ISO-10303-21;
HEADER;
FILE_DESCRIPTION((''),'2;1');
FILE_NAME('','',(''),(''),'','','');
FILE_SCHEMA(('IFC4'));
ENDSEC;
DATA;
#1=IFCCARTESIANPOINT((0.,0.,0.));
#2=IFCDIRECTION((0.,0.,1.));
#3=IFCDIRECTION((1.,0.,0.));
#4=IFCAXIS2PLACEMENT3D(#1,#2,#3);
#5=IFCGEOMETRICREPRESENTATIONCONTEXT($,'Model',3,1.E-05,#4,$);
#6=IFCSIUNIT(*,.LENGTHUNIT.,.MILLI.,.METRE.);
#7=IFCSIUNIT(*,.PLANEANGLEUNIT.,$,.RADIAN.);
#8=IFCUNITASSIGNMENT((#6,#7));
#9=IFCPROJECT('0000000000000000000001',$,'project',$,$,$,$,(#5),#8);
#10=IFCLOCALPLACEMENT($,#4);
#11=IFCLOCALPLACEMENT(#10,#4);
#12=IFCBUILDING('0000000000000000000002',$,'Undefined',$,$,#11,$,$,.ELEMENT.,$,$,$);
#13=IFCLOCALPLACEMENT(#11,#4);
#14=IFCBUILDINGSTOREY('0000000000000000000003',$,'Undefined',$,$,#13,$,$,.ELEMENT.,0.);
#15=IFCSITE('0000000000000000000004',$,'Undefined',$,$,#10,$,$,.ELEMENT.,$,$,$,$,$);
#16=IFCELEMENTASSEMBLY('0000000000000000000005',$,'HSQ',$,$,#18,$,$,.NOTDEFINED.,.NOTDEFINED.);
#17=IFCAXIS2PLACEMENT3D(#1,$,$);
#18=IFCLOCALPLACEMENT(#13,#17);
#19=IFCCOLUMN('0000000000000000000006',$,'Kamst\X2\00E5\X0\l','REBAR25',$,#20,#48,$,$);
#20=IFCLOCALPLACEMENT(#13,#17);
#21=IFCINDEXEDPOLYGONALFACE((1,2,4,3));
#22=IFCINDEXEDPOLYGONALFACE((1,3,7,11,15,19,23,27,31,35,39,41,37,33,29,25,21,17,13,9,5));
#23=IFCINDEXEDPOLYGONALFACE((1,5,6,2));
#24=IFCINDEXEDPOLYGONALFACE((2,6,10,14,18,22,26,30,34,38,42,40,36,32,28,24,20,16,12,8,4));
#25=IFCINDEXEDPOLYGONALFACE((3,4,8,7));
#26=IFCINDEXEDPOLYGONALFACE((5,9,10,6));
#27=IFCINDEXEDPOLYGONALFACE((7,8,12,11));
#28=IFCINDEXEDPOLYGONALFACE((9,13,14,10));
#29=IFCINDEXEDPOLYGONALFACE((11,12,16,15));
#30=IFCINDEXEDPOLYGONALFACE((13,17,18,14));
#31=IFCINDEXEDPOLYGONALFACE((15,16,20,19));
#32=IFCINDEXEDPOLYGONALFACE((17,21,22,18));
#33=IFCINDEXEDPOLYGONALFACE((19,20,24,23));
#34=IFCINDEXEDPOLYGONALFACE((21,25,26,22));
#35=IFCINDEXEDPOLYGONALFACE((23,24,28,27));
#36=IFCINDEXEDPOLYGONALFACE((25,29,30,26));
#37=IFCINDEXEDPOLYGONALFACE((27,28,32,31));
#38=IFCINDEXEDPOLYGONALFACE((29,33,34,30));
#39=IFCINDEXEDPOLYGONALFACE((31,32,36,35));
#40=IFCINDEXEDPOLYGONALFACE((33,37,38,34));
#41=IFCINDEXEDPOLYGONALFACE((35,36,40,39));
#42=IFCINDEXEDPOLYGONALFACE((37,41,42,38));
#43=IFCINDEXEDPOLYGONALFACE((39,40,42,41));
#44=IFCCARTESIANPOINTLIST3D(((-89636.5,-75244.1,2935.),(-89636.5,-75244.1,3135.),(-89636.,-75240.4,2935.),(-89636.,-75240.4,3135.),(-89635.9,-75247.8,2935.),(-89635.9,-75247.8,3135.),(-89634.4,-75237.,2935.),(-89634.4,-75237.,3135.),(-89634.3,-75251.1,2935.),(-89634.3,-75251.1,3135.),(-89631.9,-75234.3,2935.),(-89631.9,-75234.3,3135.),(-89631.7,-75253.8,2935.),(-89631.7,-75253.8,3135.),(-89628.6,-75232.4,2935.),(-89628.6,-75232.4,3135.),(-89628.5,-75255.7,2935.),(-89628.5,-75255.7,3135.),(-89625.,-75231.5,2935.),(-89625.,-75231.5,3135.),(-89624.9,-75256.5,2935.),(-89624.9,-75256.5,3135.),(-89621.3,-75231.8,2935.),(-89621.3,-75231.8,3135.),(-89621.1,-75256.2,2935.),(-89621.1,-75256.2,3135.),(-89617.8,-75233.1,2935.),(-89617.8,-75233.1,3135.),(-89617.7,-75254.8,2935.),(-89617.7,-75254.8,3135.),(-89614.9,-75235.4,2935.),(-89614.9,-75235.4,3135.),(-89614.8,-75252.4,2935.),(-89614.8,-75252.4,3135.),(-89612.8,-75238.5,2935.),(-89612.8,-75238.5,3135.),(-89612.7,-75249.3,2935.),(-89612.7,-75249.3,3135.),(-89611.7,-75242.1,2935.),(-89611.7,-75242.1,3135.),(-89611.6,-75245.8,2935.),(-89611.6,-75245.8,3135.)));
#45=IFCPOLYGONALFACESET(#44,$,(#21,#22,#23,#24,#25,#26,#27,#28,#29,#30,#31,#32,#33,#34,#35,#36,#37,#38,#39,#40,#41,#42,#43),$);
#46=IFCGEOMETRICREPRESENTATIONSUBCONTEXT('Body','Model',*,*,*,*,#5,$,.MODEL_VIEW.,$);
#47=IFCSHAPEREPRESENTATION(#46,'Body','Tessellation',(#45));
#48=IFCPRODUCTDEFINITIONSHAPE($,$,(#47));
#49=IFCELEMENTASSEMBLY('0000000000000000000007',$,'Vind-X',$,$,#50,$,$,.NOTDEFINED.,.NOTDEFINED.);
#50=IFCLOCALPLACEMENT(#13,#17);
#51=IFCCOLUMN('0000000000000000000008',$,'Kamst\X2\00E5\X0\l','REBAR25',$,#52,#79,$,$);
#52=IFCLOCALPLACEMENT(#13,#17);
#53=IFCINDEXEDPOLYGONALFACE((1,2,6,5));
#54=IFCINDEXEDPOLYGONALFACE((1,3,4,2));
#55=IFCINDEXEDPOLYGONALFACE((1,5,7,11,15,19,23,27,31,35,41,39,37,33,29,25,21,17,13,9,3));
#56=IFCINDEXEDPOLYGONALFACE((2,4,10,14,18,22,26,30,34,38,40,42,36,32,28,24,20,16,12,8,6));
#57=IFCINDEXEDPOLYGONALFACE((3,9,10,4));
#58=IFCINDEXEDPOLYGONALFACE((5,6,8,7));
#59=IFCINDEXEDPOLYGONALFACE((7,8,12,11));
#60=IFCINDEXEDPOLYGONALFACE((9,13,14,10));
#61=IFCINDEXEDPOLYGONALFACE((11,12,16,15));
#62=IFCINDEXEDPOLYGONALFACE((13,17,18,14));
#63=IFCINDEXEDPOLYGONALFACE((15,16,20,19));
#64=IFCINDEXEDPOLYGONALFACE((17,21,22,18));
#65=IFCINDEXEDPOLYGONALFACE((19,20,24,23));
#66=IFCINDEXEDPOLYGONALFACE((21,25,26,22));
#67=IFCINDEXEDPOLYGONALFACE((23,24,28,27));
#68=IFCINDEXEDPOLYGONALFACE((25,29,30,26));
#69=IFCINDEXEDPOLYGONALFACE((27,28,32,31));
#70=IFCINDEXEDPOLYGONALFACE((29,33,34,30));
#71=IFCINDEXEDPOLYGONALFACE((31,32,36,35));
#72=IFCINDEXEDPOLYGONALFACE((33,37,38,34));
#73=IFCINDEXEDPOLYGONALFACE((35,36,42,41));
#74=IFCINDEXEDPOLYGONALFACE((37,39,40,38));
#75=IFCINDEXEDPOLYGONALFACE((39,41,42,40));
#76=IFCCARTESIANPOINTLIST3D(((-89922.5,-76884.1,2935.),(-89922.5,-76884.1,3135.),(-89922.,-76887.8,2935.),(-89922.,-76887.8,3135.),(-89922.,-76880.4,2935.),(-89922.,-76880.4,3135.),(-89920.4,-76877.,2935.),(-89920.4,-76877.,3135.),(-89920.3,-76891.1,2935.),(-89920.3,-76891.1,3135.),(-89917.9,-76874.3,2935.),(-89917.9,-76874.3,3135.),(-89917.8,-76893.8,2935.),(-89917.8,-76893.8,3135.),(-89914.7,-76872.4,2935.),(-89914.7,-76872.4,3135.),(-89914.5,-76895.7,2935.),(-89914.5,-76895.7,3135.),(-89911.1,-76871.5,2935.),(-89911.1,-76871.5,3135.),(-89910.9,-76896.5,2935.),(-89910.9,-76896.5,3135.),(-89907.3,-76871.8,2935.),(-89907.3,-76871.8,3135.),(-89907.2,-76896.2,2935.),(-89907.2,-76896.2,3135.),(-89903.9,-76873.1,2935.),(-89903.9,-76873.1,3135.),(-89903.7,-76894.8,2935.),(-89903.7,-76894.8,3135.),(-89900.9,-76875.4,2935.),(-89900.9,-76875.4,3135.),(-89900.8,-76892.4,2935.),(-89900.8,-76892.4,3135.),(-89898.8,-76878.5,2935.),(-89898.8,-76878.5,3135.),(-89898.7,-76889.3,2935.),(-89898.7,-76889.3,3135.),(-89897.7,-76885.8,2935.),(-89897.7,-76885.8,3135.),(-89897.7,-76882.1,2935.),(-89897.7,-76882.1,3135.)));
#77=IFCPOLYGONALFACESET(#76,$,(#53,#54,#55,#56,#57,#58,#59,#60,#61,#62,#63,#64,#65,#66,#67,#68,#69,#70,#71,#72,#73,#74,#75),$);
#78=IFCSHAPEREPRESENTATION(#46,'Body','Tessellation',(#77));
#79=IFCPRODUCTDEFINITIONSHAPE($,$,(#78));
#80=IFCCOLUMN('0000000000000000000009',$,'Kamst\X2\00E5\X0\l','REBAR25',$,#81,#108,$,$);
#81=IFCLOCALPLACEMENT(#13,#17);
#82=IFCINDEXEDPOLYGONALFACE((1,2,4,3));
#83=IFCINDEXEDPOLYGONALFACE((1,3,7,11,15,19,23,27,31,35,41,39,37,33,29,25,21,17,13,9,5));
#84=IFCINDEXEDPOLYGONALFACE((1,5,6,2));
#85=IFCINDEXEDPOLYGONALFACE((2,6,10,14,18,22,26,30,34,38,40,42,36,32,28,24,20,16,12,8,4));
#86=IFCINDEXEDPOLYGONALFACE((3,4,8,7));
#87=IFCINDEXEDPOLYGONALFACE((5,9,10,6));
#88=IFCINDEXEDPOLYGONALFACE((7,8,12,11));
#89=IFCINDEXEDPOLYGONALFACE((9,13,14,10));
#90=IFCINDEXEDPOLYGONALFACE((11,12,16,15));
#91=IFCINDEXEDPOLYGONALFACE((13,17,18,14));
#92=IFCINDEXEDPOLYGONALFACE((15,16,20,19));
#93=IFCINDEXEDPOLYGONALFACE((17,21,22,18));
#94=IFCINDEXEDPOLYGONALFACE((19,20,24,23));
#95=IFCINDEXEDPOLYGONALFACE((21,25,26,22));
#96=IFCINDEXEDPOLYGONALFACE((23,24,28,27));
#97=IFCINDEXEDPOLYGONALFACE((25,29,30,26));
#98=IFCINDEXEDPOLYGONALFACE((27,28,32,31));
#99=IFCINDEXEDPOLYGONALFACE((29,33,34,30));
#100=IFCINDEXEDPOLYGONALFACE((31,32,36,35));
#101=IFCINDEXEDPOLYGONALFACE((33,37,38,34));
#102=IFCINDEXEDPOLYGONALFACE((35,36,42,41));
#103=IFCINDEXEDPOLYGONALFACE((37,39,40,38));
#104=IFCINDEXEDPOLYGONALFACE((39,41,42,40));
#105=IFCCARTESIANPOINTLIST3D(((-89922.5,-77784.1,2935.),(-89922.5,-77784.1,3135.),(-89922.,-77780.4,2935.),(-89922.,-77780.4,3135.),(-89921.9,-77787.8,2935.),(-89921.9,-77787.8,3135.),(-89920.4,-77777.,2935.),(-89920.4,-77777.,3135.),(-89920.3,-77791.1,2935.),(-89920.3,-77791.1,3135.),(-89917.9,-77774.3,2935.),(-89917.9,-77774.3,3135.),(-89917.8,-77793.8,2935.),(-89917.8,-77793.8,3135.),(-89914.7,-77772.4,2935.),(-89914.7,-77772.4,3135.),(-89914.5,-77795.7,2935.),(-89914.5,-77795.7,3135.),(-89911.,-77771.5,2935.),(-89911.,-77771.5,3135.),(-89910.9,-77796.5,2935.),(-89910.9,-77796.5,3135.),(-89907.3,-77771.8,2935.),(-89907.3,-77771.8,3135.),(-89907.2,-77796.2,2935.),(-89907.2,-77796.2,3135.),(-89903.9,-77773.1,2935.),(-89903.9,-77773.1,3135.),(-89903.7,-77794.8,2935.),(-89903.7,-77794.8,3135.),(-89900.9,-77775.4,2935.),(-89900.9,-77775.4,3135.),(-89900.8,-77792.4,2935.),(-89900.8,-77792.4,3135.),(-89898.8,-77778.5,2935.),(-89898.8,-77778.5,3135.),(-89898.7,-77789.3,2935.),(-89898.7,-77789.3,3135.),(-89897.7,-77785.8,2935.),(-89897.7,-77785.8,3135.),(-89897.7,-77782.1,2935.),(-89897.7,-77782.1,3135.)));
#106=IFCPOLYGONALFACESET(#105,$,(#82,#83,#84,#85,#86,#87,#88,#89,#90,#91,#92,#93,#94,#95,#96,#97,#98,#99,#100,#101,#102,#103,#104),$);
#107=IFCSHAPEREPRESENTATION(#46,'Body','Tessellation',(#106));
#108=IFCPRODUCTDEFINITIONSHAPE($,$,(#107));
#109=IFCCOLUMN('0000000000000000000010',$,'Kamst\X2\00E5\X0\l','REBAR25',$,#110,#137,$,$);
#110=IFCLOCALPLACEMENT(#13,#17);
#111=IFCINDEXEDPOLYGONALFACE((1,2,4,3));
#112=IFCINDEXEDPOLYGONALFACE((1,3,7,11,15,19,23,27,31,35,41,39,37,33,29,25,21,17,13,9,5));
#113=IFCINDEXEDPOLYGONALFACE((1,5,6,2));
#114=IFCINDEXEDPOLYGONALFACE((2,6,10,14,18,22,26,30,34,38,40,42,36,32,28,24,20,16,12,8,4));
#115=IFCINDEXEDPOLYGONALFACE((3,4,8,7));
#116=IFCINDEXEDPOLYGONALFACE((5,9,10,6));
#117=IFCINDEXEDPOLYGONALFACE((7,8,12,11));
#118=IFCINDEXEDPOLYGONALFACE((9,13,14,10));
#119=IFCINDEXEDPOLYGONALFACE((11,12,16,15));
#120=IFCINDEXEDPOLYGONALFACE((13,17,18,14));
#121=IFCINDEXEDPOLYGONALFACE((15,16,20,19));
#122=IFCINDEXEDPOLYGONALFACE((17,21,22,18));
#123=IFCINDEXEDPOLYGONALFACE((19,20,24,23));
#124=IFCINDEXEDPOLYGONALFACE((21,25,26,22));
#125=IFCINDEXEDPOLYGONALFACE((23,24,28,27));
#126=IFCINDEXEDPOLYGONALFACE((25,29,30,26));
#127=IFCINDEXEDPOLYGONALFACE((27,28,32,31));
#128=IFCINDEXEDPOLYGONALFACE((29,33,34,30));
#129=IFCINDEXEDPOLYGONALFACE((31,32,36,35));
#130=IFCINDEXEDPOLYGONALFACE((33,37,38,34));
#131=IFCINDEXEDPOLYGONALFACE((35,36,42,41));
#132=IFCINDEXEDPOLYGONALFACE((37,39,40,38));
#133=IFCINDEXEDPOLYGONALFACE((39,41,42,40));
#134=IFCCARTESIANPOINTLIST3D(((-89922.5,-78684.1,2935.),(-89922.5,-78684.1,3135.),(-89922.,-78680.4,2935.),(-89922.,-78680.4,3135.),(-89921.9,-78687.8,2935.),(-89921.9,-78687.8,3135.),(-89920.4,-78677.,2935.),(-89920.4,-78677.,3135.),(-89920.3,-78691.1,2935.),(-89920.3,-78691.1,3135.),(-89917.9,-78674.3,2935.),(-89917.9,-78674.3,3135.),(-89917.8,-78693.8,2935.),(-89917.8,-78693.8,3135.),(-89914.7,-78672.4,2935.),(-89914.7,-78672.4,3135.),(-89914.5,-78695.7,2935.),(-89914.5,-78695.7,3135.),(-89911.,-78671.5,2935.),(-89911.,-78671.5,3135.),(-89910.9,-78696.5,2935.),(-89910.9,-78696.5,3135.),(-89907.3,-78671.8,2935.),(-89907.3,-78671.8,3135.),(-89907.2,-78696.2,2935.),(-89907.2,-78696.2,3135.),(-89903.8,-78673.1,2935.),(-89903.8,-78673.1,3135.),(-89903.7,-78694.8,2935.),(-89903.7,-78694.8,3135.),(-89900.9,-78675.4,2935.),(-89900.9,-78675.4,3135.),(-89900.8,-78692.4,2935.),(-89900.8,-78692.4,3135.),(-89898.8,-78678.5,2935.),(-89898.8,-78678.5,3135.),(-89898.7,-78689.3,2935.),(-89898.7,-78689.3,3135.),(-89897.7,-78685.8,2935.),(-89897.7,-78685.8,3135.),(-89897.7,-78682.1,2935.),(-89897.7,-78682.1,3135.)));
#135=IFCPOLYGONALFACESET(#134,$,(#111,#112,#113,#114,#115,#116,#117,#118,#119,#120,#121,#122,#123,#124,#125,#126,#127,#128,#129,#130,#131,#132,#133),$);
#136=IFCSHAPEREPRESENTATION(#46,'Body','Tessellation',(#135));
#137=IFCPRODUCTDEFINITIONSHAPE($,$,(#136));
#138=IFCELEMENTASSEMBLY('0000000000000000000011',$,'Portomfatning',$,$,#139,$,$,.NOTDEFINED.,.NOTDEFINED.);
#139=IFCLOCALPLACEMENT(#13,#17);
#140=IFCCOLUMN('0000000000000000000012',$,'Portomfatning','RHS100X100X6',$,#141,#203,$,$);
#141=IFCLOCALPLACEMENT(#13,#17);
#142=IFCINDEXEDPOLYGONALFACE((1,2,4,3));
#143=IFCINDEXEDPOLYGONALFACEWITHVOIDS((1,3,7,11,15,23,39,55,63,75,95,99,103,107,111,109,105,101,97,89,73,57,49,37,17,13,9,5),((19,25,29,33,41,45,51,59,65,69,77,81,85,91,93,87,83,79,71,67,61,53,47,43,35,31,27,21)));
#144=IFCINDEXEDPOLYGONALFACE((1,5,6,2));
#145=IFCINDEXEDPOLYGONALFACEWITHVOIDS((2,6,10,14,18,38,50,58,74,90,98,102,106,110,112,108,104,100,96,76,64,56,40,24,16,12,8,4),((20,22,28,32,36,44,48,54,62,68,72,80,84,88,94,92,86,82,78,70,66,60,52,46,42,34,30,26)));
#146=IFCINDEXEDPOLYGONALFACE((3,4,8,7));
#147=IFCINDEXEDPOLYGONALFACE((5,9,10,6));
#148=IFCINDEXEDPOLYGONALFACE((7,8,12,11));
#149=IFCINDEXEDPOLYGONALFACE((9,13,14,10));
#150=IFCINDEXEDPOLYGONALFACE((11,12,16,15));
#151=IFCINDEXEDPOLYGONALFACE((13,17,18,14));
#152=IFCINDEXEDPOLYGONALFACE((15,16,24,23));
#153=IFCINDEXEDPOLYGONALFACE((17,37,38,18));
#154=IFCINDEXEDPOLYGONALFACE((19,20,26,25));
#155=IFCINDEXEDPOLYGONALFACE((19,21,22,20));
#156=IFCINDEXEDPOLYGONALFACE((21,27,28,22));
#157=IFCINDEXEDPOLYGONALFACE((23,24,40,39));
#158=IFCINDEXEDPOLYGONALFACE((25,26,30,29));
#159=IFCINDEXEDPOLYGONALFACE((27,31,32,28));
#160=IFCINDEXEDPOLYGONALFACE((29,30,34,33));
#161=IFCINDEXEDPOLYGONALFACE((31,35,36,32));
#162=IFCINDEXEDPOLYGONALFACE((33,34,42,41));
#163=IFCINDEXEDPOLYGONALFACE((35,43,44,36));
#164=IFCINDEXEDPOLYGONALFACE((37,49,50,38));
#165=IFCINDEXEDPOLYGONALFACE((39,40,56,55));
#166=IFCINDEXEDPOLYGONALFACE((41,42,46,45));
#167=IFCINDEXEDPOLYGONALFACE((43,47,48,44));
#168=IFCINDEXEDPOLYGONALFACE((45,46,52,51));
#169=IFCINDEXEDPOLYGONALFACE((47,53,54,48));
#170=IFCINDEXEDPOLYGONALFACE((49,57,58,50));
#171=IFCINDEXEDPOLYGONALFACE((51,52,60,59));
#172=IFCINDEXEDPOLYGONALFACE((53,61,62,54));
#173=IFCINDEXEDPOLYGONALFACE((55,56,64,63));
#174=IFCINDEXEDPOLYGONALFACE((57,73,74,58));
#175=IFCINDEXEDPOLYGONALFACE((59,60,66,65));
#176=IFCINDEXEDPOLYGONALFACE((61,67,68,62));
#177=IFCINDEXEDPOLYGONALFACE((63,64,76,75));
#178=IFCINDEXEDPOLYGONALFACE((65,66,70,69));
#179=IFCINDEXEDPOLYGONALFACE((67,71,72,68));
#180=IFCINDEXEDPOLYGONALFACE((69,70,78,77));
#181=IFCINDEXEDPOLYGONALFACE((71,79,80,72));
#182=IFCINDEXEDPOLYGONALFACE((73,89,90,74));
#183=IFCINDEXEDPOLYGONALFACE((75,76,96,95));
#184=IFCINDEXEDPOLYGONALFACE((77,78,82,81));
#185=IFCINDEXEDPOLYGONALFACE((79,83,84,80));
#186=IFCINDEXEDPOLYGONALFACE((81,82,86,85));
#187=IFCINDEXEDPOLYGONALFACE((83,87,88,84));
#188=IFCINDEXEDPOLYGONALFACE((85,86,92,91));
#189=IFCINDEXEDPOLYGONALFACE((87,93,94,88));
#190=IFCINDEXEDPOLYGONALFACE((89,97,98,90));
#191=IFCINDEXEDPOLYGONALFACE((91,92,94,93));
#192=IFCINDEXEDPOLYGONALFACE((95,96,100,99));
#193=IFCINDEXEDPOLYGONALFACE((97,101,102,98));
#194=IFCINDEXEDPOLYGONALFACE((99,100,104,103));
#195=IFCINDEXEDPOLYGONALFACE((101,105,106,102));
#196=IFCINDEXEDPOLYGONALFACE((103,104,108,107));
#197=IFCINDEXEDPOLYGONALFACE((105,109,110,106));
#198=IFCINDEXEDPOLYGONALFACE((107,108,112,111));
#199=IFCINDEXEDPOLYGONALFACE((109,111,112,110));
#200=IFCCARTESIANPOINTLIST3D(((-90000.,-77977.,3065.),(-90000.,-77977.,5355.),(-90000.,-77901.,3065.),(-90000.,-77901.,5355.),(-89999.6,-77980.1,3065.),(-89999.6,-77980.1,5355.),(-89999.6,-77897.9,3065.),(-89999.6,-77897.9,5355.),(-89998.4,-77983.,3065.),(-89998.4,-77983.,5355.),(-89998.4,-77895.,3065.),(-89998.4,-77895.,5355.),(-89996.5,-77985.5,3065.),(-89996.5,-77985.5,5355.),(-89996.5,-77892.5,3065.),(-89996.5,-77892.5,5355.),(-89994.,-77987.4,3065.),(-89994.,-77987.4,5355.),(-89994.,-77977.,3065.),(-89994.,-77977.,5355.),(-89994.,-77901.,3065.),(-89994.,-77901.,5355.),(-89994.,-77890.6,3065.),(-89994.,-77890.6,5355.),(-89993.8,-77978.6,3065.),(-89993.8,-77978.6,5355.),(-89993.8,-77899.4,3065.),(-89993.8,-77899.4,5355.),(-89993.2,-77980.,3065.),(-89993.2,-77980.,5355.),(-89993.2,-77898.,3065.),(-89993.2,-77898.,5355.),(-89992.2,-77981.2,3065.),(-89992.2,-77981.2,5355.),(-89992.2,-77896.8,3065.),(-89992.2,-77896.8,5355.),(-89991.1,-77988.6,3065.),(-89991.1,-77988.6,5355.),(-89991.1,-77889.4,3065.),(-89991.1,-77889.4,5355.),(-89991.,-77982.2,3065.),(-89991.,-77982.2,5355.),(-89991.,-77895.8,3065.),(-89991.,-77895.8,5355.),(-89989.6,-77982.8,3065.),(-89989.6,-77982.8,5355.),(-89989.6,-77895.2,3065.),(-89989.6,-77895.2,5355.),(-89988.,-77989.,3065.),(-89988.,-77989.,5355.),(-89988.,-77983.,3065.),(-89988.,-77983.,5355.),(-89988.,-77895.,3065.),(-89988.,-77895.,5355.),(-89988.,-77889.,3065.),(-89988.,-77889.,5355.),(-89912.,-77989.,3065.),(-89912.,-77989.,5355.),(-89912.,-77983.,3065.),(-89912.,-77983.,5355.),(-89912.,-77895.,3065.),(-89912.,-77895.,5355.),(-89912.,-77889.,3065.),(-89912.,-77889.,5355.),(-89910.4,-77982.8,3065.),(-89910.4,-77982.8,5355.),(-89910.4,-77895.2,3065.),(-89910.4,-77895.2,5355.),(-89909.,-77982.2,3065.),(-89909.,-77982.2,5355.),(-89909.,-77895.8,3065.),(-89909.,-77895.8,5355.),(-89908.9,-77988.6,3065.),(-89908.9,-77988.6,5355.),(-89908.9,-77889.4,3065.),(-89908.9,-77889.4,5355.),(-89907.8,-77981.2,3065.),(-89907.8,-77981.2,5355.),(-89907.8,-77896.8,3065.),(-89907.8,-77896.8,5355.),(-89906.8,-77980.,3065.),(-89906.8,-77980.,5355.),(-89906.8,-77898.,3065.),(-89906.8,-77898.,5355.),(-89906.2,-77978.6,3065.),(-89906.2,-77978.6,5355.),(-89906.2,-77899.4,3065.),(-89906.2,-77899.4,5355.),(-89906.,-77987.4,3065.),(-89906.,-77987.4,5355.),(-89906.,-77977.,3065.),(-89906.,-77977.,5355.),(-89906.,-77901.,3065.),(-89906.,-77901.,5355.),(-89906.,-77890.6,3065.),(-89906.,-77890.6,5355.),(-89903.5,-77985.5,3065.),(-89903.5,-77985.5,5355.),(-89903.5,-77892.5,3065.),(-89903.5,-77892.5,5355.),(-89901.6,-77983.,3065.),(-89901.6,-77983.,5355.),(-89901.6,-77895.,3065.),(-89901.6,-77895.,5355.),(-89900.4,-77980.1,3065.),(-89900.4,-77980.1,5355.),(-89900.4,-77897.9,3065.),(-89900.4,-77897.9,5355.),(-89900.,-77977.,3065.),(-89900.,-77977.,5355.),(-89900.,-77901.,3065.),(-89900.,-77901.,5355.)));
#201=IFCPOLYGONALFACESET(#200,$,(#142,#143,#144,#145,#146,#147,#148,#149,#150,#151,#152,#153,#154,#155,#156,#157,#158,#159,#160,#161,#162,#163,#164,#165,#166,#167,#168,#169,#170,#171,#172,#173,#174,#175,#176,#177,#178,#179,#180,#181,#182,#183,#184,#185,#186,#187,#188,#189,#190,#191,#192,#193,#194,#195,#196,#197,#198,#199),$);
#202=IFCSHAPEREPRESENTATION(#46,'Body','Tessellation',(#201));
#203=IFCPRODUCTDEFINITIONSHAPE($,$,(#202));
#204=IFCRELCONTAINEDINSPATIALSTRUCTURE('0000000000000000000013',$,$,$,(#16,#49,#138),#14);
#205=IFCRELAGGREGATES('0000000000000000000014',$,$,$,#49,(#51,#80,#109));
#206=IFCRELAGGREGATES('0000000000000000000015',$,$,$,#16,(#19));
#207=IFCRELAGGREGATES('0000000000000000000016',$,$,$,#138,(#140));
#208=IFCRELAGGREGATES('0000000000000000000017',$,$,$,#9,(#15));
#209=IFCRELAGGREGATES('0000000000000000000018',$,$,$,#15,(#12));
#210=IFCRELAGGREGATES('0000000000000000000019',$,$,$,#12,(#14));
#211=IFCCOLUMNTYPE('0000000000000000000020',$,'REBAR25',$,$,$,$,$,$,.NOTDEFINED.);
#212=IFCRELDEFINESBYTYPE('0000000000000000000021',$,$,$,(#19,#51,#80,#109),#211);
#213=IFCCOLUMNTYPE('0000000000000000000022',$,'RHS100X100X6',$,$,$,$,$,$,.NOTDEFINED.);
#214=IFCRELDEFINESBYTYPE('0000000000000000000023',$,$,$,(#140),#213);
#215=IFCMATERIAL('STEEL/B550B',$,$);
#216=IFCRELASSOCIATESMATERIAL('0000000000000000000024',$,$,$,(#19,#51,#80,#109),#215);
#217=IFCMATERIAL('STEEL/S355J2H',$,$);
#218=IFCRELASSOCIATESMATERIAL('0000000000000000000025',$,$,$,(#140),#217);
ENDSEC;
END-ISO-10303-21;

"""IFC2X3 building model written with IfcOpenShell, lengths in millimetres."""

from ifc_helpers import new_model, si_unit, frame, origin_with_axes, origin_2d_with_axis, place, context, subcontext, project, spatial, hollow_rectangle, circle, extrude, clip, halfspace, material, type_object, element, aggregate, save


model = new_model("IFC2X3")

# Units and contexts
model_context = context("Model", 3, precision=1e-05, world=origin_with_axes())
body_context = subcontext(model_context, "Body", "Model", "MODEL_VIEW")
ifc_project = project(units=[si_unit("LENGTHUNIT", "METRE", prefix="MILLI"), si_unit("PLANEANGLEUNIT", "RADIAN")], contexts=[model_context])

# Site, building, storey
site_placement = place(None, origin_with_axes())
site = spatial("IfcSite", under=ifc_project, at=site_placement, Name="Undefined", CompositionType="ELEMENT")
building_placement = place(site_placement, origin_with_axes())
building = spatial("IfcBuilding", under=site, at=building_placement, Name="Undefined", CompositionType="ELEMENT")
storey_placement = place(building_placement, origin_with_axes())
storey = spatial("IfcBuildingStorey", under=building, at=storey_placement, Name="Undefined", CompositionType="ELEMENT", Elevation=0.0)

# Element assembly, column
assembly_1_placement = place(storey_placement, origin_with_axes())
assembly_1 = element("IfcElementAssembly", 1, at=assembly_1_placement, inside=storey, Name="HSQ", AssemblyPlace="NOTDEFINED", PredefinedType="NOTDEFINED")
ifc_material_1 = material(Name="STEEL/B550B")
column_type_1 = type_object("IfcColumnType", Name="REBAR25", PredefinedType="NOTDEFINED")
column_1_placement = place(assembly_1_placement, frame((-89624.0, -75244.0, 2935.0), z_axis=(0.0, 0.0, 1.0), x_axis=(-0.862746, -0.505638, 0.0)))
column_1 = element("IfcColumn", 2, at=column_1_placement, type_object=column_type_1, material=ifc_material_1, Name="Kamstål", Description="REBAR25", context=body_context, shape_type="SweptSolid", body=[
    extrude(circle(Radius=12.5, at=origin_2d_with_axis()), frame((0.0, 0.0, 200.0), z_axis=(0.0, 0.0, -1.0), x_axis=(0.0, 1.0, 0.0)), (0.0, 0.0, 1.0), 200.0),
])

# Element assembly, columns
assembly_2_placement = place(storey_placement, origin_with_axes())
assembly_2 = element("IfcElementAssembly", 3, at=assembly_2_placement, inside=storey, Name="Vind-X", AssemblyPlace="NOTDEFINED", PredefinedType="NOTDEFINED")
column_2_placement = place(assembly_2_placement, frame((-89910.0, -76884.0, 2935.0), z_axis=(0.0, 0.0, 1.0), x_axis=(-0.862746, -0.505638, 0.0)))
column_2 = element("IfcColumn", 4, at=column_2_placement, type_object=column_type_1, material=ifc_material_1, Name="Kamstål", Description="REBAR25", context=body_context, shape_type="SweptSolid", body=[
    extrude(circle(Radius=12.5, at=origin_2d_with_axis()), frame((0.0, 0.0, 200.0), z_axis=(0.0, 0.0, -1.0), x_axis=(0.0, 1.0, 0.0)), (0.0, 0.0, 1.0), 200.0),
])
column_3_placement = place(assembly_2_placement, frame((-89910.0, -77784.0, 2935.0), z_axis=(0.0, 0.0, 1.0), x_axis=(-0.862746, -0.505638, 0.0)))
column_3 = element("IfcColumn", 5, at=column_3_placement, type_object=column_type_1, material=ifc_material_1, Name="Kamstål", Description="REBAR25", context=body_context, shape_type="SweptSolid", body=[
    extrude(circle(Radius=12.5, at=origin_2d_with_axis()), frame((0.0, 0.0, 200.0), z_axis=(0.0, 0.0, -1.0), x_axis=(0.0, 1.0, 0.0)), (0.0, 0.0, 1.0), 200.0),
])
column_4_placement = place(assembly_2_placement, frame((-89910.0, -78684.0, 2935.0), z_axis=(0.0, 0.0, 1.0), x_axis=(-0.862746, -0.505638, 0.0)))
column_4 = element("IfcColumn", 6, at=column_4_placement, type_object=column_type_1, material=ifc_material_1, Name="Kamstål", Description="REBAR25", context=body_context, shape_type="SweptSolid", body=[
    extrude(circle(Radius=12.5, at=origin_2d_with_axis()), frame((0.0, 0.0, 200.0), z_axis=(0.0, 0.0, -1.0), x_axis=(0.0, 1.0, 0.0)), (0.0, 0.0, 1.0), 200.0),
])

# Element assembly, column
assembly_3_placement = place(storey_placement, origin_with_axes())
assembly_3 = element("IfcElementAssembly", 7, at=assembly_3_placement, inside=storey, Name="Portomfatning", AssemblyPlace="NOTDEFINED", PredefinedType="NOTDEFINED")
ifc_material_2 = material(Name="STEEL/S355J2H")
column_type_2 = type_object("IfcColumnType", Name="RHS100X100X6", PredefinedType="NOTDEFINED")
column_5_placement = place(assembly_3_placement, frame((-89950.0, -77939.0, 3065.0), z_axis=(0.0, 0.0, 1.0), x_axis=(0.0, -1.0, 0.0)))
column_5 = element("IfcColumn", 8, at=column_5_placement, type_object=column_type_2, material=ifc_material_2, Name="Portomfatning", Description="RHS100X100X6", context=body_context, shape_type="Clipping", body=[
    clip(extrude(hollow_rectangle(XDim=100.0, YDim=100.0, WallThickness=6.0, InnerFilletRadius=6.0, OuterFilletRadius=12.0, at=origin_2d_with_axis()), frame((0.0, 0.0, 2290.0), z_axis=(0.0, 0.0, -1.0), x_axis=(0.0, 1.0, 0.0)), (0.0, 0.0, 1.0), 2290.0), halfspace(frame((50.0, 0.0, 2290.0), z_axis=(0.0, 0.0, -1.0), x_axis=(0.0, 1.0, 0.0)), True)),
])

aggregate(assembly_2, [column_2, column_3, column_4])
aggregate(assembly_1, [column_1])
aggregate(assembly_3, [column_5])

save(model, "model.ifc")
